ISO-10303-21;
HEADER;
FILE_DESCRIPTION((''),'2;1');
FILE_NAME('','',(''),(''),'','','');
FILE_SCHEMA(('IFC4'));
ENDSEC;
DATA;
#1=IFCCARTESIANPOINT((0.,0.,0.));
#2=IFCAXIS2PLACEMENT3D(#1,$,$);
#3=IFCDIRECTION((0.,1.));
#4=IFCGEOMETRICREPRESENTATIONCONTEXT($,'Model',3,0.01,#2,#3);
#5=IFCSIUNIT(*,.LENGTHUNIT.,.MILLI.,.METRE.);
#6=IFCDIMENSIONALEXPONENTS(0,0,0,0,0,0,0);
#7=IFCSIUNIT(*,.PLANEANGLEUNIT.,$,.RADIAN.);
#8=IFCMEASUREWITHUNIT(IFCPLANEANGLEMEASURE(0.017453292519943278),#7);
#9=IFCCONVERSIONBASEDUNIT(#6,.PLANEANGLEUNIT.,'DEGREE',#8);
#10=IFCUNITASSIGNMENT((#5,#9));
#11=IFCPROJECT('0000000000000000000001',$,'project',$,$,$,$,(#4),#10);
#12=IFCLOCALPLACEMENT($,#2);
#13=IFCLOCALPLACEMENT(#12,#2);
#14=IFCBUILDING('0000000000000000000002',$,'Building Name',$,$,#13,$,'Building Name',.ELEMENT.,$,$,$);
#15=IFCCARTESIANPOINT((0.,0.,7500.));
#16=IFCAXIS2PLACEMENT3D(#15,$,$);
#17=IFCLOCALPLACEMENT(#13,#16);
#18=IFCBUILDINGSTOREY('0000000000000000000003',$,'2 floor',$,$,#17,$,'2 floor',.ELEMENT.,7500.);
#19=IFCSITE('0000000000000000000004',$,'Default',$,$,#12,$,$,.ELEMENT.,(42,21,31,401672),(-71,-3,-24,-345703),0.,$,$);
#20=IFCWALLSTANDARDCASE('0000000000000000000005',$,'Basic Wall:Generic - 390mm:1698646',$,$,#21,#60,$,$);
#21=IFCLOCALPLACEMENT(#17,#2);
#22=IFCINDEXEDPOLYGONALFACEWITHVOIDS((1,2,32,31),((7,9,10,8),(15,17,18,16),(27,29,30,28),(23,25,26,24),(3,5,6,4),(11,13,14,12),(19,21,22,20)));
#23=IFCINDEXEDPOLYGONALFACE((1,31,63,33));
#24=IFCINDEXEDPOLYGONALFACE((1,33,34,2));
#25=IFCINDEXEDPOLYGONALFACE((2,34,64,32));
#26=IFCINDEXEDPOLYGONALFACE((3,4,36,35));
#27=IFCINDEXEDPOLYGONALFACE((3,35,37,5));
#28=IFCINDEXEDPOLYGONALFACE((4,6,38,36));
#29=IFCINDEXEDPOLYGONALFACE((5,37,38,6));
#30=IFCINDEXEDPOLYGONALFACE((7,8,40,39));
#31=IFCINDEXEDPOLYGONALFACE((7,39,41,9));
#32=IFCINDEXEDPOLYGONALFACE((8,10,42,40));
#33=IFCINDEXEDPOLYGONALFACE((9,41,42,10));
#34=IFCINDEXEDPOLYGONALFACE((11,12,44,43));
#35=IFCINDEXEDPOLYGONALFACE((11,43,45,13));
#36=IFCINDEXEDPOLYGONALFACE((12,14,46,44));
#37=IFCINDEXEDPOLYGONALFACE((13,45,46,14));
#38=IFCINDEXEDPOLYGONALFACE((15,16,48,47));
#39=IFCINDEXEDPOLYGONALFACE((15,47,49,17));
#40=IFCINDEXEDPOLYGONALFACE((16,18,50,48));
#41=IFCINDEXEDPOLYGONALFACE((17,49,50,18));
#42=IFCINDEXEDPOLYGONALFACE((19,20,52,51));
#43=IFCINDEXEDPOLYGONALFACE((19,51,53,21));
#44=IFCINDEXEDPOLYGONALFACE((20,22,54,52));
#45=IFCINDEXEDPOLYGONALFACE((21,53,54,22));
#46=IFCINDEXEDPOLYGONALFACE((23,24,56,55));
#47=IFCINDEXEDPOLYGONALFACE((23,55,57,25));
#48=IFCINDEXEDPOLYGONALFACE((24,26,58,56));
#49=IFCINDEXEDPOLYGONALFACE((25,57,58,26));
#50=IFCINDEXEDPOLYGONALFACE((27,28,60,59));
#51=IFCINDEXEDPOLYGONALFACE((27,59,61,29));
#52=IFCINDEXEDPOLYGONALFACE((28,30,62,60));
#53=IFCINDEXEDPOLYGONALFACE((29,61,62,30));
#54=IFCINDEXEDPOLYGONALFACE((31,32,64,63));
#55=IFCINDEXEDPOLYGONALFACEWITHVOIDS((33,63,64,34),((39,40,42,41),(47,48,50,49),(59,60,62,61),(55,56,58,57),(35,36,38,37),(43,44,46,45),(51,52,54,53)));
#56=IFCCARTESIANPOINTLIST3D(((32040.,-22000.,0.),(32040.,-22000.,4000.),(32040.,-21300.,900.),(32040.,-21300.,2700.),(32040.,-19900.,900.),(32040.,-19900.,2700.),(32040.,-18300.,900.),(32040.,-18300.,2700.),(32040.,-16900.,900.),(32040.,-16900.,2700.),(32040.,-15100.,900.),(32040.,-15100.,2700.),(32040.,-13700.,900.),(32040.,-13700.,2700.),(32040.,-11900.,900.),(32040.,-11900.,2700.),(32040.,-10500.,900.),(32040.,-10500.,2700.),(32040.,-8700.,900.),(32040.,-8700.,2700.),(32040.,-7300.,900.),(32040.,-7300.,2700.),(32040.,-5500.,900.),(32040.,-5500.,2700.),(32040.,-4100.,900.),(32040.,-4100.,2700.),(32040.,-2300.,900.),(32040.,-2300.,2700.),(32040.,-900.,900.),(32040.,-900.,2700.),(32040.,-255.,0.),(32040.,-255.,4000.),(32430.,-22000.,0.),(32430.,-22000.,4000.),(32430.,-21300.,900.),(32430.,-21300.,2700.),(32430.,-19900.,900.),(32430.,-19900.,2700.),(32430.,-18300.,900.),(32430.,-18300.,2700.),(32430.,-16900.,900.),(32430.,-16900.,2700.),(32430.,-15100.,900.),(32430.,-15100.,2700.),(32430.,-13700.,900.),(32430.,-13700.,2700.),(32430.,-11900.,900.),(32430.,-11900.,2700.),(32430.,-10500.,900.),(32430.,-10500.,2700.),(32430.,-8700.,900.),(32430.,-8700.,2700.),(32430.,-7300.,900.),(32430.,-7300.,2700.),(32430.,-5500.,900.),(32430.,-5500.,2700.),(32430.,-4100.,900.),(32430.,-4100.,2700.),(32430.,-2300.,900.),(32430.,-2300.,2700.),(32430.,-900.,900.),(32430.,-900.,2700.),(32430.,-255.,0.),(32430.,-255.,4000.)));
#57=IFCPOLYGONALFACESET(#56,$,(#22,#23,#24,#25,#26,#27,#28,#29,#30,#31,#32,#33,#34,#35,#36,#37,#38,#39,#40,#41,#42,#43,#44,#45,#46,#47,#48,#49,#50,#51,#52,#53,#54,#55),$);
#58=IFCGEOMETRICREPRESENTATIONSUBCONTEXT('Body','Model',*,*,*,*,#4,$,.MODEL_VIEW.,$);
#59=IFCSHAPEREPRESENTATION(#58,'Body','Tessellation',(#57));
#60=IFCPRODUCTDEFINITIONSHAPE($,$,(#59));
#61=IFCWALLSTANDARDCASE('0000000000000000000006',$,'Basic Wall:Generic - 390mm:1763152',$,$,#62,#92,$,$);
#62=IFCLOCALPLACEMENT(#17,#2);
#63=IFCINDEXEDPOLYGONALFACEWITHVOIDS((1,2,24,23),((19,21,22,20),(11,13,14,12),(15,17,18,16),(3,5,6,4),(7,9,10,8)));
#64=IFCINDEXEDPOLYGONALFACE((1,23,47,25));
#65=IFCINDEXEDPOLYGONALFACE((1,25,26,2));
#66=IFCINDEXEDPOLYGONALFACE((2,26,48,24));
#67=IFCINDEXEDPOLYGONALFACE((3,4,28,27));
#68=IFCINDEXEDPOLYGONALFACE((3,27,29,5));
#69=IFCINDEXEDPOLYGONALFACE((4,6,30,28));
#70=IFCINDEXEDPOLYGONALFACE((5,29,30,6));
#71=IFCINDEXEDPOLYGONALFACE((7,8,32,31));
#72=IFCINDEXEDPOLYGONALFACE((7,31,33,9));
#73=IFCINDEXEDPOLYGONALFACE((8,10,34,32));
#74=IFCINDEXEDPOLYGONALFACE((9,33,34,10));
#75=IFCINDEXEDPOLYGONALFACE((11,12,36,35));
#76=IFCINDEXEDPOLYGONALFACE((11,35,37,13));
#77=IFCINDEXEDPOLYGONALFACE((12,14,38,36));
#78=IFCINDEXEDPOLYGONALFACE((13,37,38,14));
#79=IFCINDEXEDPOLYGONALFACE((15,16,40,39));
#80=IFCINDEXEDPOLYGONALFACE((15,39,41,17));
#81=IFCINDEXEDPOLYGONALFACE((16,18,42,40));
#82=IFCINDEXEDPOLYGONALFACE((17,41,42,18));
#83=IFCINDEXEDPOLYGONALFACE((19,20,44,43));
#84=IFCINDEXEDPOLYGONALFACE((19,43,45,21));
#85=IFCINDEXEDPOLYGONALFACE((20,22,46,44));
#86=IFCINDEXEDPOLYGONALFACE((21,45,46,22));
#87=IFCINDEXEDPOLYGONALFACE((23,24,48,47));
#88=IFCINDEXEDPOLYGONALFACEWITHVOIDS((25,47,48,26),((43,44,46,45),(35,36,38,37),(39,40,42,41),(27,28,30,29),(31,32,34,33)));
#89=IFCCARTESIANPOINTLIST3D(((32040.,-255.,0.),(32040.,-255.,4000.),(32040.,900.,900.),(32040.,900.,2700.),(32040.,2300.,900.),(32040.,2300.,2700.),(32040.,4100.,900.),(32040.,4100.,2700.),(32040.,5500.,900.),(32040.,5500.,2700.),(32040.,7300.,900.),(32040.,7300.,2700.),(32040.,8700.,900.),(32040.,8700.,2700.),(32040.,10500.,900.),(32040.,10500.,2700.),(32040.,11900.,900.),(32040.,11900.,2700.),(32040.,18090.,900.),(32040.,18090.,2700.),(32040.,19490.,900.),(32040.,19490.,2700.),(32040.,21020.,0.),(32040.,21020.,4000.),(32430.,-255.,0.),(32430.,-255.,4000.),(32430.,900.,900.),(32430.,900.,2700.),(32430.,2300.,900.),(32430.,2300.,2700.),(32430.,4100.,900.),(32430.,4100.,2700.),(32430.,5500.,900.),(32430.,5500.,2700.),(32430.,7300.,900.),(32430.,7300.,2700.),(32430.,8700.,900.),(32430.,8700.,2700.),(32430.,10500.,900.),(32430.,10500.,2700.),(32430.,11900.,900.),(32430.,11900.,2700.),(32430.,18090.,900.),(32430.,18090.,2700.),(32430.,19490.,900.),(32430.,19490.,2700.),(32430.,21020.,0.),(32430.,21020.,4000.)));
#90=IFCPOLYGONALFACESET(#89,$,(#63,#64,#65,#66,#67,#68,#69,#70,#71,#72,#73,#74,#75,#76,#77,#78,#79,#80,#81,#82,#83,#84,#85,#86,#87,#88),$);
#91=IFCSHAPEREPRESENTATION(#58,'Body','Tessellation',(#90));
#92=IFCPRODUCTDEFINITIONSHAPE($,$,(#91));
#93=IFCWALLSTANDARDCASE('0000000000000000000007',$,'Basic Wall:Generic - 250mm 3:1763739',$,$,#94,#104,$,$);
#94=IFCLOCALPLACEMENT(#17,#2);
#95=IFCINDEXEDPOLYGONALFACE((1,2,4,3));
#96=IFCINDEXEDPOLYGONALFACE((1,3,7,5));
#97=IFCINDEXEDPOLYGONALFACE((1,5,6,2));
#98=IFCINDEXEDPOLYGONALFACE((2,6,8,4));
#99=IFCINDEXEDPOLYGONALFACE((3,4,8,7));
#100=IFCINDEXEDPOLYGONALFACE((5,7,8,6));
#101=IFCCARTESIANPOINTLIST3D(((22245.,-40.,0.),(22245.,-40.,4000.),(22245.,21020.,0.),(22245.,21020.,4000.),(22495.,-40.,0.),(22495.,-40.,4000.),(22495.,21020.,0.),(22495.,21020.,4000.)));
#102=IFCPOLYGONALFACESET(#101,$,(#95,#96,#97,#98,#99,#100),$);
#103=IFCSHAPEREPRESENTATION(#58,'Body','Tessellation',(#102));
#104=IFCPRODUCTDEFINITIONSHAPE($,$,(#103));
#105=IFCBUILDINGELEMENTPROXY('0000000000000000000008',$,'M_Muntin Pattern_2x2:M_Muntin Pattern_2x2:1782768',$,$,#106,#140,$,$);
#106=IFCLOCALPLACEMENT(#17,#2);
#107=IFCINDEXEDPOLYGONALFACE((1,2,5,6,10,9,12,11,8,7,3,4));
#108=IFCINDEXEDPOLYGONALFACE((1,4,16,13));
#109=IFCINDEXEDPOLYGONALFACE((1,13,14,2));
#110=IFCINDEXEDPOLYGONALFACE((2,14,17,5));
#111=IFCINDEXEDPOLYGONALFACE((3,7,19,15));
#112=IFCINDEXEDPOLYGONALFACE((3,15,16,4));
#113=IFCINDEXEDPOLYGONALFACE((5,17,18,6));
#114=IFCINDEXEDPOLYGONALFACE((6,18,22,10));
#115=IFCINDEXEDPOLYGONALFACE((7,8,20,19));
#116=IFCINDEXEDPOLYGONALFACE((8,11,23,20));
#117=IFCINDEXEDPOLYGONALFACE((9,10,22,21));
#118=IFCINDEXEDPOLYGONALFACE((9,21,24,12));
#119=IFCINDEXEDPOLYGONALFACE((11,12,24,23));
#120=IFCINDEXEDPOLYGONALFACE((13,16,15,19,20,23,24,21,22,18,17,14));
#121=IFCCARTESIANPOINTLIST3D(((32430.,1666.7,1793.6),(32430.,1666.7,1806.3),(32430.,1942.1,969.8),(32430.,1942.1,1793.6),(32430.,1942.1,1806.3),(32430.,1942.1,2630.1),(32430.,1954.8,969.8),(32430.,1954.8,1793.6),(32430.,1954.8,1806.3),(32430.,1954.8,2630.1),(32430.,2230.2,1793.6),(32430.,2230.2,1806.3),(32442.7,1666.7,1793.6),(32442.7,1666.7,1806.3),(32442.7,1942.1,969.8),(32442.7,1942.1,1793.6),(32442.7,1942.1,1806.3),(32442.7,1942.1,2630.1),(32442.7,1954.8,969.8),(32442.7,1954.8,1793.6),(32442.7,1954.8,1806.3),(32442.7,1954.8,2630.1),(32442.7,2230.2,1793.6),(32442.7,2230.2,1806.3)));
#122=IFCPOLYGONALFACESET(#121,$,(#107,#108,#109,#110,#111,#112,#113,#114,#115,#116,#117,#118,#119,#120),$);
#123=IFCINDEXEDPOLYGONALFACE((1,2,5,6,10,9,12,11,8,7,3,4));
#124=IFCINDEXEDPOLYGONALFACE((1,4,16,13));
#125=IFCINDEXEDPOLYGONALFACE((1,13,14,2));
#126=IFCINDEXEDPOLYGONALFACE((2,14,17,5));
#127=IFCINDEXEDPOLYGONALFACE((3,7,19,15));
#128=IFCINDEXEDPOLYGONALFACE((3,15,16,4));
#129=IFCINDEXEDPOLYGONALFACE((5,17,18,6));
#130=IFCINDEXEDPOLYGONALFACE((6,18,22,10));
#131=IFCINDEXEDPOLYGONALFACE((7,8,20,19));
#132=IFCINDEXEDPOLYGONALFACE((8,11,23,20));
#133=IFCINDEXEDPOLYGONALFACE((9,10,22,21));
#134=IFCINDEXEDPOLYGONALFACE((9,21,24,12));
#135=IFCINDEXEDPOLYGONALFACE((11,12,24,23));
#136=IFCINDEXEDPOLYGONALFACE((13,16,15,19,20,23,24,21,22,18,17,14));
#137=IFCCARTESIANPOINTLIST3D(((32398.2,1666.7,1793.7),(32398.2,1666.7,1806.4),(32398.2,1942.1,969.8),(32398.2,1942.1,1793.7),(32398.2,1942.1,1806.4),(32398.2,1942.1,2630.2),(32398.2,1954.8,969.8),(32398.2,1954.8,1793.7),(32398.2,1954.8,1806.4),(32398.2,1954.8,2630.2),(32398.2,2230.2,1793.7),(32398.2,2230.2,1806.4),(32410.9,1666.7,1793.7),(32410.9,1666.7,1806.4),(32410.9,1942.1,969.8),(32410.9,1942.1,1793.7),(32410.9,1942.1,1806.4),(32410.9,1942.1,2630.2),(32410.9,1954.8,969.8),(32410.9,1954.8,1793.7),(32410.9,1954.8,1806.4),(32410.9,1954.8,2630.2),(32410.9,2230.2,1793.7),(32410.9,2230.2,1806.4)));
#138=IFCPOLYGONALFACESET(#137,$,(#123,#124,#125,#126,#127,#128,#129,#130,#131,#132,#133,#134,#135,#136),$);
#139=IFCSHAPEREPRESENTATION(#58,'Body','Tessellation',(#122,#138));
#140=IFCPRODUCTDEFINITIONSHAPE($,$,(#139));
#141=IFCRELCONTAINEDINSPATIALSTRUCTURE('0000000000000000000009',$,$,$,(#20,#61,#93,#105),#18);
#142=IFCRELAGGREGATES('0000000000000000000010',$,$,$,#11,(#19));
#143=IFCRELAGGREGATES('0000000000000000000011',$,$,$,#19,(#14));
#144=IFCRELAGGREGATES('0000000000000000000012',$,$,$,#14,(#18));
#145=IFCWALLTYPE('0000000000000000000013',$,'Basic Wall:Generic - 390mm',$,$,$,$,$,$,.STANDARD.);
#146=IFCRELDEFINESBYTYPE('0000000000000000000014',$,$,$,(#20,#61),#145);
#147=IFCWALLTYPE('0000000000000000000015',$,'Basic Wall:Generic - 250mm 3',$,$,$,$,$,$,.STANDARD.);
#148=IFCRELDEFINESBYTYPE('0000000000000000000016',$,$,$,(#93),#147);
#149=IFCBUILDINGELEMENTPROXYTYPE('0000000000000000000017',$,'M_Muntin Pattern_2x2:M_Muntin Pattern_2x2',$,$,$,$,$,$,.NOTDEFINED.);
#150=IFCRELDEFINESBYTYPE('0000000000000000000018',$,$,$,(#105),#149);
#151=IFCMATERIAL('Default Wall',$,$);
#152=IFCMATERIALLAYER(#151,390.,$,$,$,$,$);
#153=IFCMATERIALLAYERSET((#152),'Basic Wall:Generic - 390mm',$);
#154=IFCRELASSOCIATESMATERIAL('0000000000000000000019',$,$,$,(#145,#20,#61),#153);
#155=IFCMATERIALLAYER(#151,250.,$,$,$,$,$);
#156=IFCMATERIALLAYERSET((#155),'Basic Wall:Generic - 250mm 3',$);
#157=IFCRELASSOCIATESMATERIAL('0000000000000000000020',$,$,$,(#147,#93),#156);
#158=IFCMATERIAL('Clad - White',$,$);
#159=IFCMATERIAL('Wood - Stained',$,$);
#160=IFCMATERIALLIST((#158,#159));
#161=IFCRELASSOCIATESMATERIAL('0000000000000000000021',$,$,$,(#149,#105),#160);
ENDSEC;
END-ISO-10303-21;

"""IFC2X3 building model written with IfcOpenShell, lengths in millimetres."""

from ifc_helpers import new_model, entity, si_unit, converted_unit, direction, frame, frame_2d, origin, place, context, subcontext, project, spatial, polyline, rectangle, outline, extrude, source, transform, mapped, material, material_list, layer, layer_set, layer_usage, type_object, type_shapes, element, save


model = new_model("IFC2X3")

# Units and contexts
model_context = context("Model", 3, precision=0.01, world=origin(), true_north=direction((0.0, 1.0)))
body_context = subcontext(model_context, "Body", "Model", "MODEL_VIEW")
ifc_project = project(units=[si_unit("LENGTHUNIT", "METRE", prefix="MILLI"), converted_unit("PLANEANGLEUNIT", "DEGREE", entity("IfcPlaneAngleMeasure", 0.017453292519943278), si_unit("PLANEANGLEUNIT", "RADIAN"), dimensions=[0, 0, 0, 0, 0, 0, 0])], contexts=[model_context])

# Site, building, storey
site_placement = place(None, origin())
site = spatial("IfcSite", under=ifc_project, at=site_placement, Name="Default", CompositionType="ELEMENT", RefLatitude=(42, 21, 31, 401672), RefLongitude=(-71, -3, -24, -345703), RefElevation=0.0)
building_placement = place(site_placement, origin())
building = spatial("IfcBuilding", under=site, at=building_placement, Name="Building Name", LongName="Building Name", CompositionType="ELEMENT")
storey_placement = place(building_placement, frame((0.0, 0.0, 7500.0)))
storey = spatial("IfcBuildingStorey", under=building, at=storey_placement, Name="2 floor", LongName="2 floor", CompositionType="ELEMENT", Elevation=7500.0)

# Walls, openings
ifc_material_1 = material(Name="Default Wall")
ifc_layer_1 = layer(ifc_material_1, 390.0)
ifc_layer_set_1 = layer_set([ifc_layer_1], Name="Basic Wall:Generic - 390mm")
ifc_layer_usage_1 = layer_usage(ifc_layer_set_1, "AXIS2", "NEGATIVE", 195.0)
wall_type_1 = type_object("IfcWallType", Name="Basic Wall:Generic - 390mm", PredefinedType="STANDARD", material=ifc_layer_set_1)
wall_1_placement = place(storey_placement, frame((32235.0, -255.0, 0.0), z_axis=(0.0, 0.0, 1.0), x_axis=(0.0, -1.0, 0.0)))
wall_1 = element("IfcWallStandardCase", 1, at=wall_1_placement, inside=storey, type_object=wall_type_1, material=ifc_layer_usage_1, Name="Basic Wall:Generic - 390mm:1698646", context=body_context, shape_type="SweptSolid", body=[
    extrude(rectangle(XDim=21745.0, YDim=390.0, at=frame_2d((10872.5, 0.0), x_axis=(-1.0, 0.0))), origin(), (0.0, 0.0, 1.0), 4000.0),
])
opening_1_placement = place(wall_1_placement, frame((645.0, -195.0, 900.0)))
element("IfcOpeningElement", 2, at=opening_1_placement, cuts=wall_1, ObjectType="Opening", context=body_context, shape_type="SweptSolid", body=[
    extrude(rectangle(XDim=1800.0, YDim=1400.0, at=frame_2d((900.0, 700.0), x_axis=(-1.0, 0.0))), frame((0.0, 0.0, 0.0), z_axis=(0.0, 1.0, 0.0), x_axis=(0.0, 0.0, 1.0)), (0.0, 0.0, 1.0), 390.0),
])
opening_2_placement = place(wall_1_placement, frame((3845.0, -195.0, 900.0)))
element("IfcOpeningElement", 3, at=opening_2_placement, cuts=wall_1, ObjectType="Opening", context=body_context, shape_type="SweptSolid", body=[
    extrude(rectangle(XDim=1800.0, YDim=1400.0, at=frame_2d((900.0, 700.0), x_axis=(-1.0, 0.0))), frame((0.0, 0.0, 0.0), z_axis=(0.0, 1.0, 0.0), x_axis=(0.0, 0.0, 1.0)), (0.0, 0.0, 1.0), 390.0),
])
opening_3_placement = place(wall_1_placement, frame((7045.0, -195.0, 900.0)))
element("IfcOpeningElement", 4, at=opening_3_placement, cuts=wall_1, ObjectType="Opening", context=body_context, shape_type="SweptSolid", body=[
    extrude(rectangle(XDim=1800.0, YDim=1400.0, at=frame_2d((900.0, 700.0), x_axis=(-1.0, 0.0))), frame((0.0, 0.0, 0.0), z_axis=(0.0, 1.0, 0.0), x_axis=(0.0, 0.0, 1.0)), (0.0, 0.0, 1.0), 390.0),
])
opening_4_placement = place(wall_1_placement, frame((10245.0, -195.0, 900.0)))
element("IfcOpeningElement", 5, at=opening_4_placement, cuts=wall_1, ObjectType="Opening", context=body_context, shape_type="SweptSolid", body=[
    extrude(rectangle(XDim=1800.0, YDim=1400.0, at=frame_2d((900.0, 700.0), x_axis=(-1.0, 0.0))), frame((0.0, 0.0, 0.0), z_axis=(0.0, 1.0, 0.0), x_axis=(0.0, 0.0, 1.0)), (0.0, 0.0, 1.0), 390.0),
])
opening_5_placement = place(wall_1_placement, frame((13445.0, -195.0, 900.0)))
element("IfcOpeningElement", 6, at=opening_5_placement, cuts=wall_1, ObjectType="Opening", context=body_context, shape_type="SweptSolid", body=[
    extrude(rectangle(XDim=1800.0, YDim=1400.0, at=frame_2d((900.0, 700.0), x_axis=(-1.0, 0.0))), frame((0.0, 0.0, 0.0), z_axis=(0.0, 1.0, 0.0), x_axis=(0.0, 0.0, 1.0)), (0.0, 0.0, 1.0), 390.0),
])
opening_6_placement = place(wall_1_placement, frame((16645.0, -195.0, 900.0)))
element("IfcOpeningElement", 7, at=opening_6_placement, cuts=wall_1, ObjectType="Opening", context=body_context, shape_type="SweptSolid", body=[
    extrude(rectangle(XDim=1800.0, YDim=1400.0, at=frame_2d((900.0, 700.0), x_axis=(-1.0, 0.0))), frame((0.0, 0.0, 0.0), z_axis=(0.0, 1.0, 0.0), x_axis=(0.0, 0.0, 1.0)), (0.0, 0.0, 1.0), 390.0),
])
opening_7_placement = place(wall_1_placement, frame((19645.0, -195.0, 900.0)))
element("IfcOpeningElement", 8, at=opening_7_placement, cuts=wall_1, ObjectType="Opening", context=body_context, shape_type="SweptSolid", body=[
    extrude(rectangle(XDim=1800.0, YDim=1400.0, at=frame_2d((900.0, 700.0), x_axis=(-1.0, 0.0))), frame((0.0, 0.0, 0.0), z_axis=(0.0, 1.0, 0.0), x_axis=(0.0, 0.0, 1.0)), (0.0, 0.0, 1.0), 390.0),
])
ifc_layer_usage_2 = layer_usage(ifc_layer_set_1, "AXIS2", "NEGATIVE", 195.0)
wall_2_placement = place(storey_placement, frame((32235.0, -255.0, 0.0), z_axis=(0.0, 0.0, 1.0), x_axis=(0.0, 1.0, 0.0)))
wall_2 = element("IfcWallStandardCase", 9, at=wall_2_placement, inside=storey, type_object=wall_type_1, material=ifc_layer_usage_2, Name="Basic Wall:Generic - 390mm:1763152", context=body_context, shape_type="SweptSolid", body=[
    extrude(rectangle(XDim=21275.0, YDim=390.0, at=frame_2d((10637.5, 0.0), x_axis=(-1.0, 0.0))), origin(), (0.0, 0.0, 1.0), 4000.0),
])
opening_8_placement = place(wall_2_placement, frame((19745.0, 195.0, 900.0)))
element("IfcOpeningElement", 10, at=opening_8_placement, cuts=wall_2, ObjectType="Opening", context=body_context, shape_type="SweptSolid", body=[
    extrude(rectangle(XDim=1800.0, YDim=1400.0, at=frame_2d((900.0, 700.0), x_axis=(-1.0, 0.0))), frame((0.0, 0.0, 0.0), z_axis=(0.0, -1.0, 0.0), x_axis=(0.0, 0.0, 1.0)), (0.0, 0.0, 1.0), 390.0),
])
opening_9_placement = place(wall_2_placement, frame((12155.0, 195.0, 900.0)))
element("IfcOpeningElement", 11, at=opening_9_placement, cuts=wall_2, ObjectType="Opening", context=body_context, shape_type="SweptSolid", body=[
    extrude(rectangle(XDim=1800.0, YDim=1400.0, at=frame_2d((900.0, 700.0), x_axis=(-1.0, 0.0))), frame((0.0, 0.0, 0.0), z_axis=(0.0, -1.0, 0.0), x_axis=(0.0, 0.0, 1.0)), (0.0, 0.0, 1.0), 390.0),
])
opening_10_placement = place(wall_2_placement, frame((8955.0, 195.0, 900.0)))
element("IfcOpeningElement", 12, at=opening_10_placement, cuts=wall_2, ObjectType="Opening", context=body_context, shape_type="SweptSolid", body=[
    extrude(rectangle(XDim=1800.0, YDim=1400.0, at=frame_2d((900.0, 700.0), x_axis=(-1.0, 0.0))), frame((0.0, 0.0, 0.0), z_axis=(0.0, -1.0, 0.0), x_axis=(0.0, 0.0, 1.0)), (0.0, 0.0, 1.0), 390.0),
])
opening_11_placement = place(wall_2_placement, frame((5755.0, 195.0, 900.0)))
element("IfcOpeningElement", 13, at=opening_11_placement, cuts=wall_2, ObjectType="Opening", context=body_context, shape_type="SweptSolid", body=[
    extrude(rectangle(XDim=1800.0, YDim=1400.0, at=frame_2d((900.0, 700.0), x_axis=(-1.0, 0.0))), frame((0.0, 0.0, 0.0), z_axis=(0.0, -1.0, 0.0), x_axis=(0.0, 0.0, 1.0)), (0.0, 0.0, 1.0), 390.0),
])
opening_12_placement = place(wall_2_placement, frame((2555.0, 195.0, 900.0)))
element("IfcOpeningElement", 14, at=opening_12_placement, cuts=wall_2, ObjectType="Opening", context=body_context, shape_type="SweptSolid", body=[
    extrude(rectangle(XDim=1800.0, YDim=1400.0, at=frame_2d((900.0, 700.0), x_axis=(-1.0, 0.0))), frame((0.0, 0.0, 0.0), z_axis=(0.0, -1.0, 0.0), x_axis=(0.0, 0.0, 1.0)), (0.0, 0.0, 1.0), 390.0),
])

# Wall
ifc_layer_2 = layer(ifc_material_1, 250.0)
ifc_layer_set_2 = layer_set([ifc_layer_2], Name="Basic Wall:Generic - 250mm 3")
ifc_layer_usage_3 = layer_usage(ifc_layer_set_2, "AXIS2", "NEGATIVE", 125.0)
wall_type_2 = type_object("IfcWallType", Name="Basic Wall:Generic - 250mm 3", PredefinedType="STANDARD", material=ifc_layer_set_2)
wall_3_placement = place(storey_placement, frame((22370.0, -40.0, 0.0), z_axis=(0.0, 0.0, 1.0), x_axis=(0.0, 1.0, 0.0)))
element("IfcWallStandardCase", 15, at=wall_3_placement, inside=storey, type_object=wall_type_2, material=ifc_layer_usage_3, Name="Basic Wall:Generic - 250mm 3:1763739", context=body_context, shape_type="SweptSolid", body=[
    extrude(rectangle(XDim=21060.0, YDim=250.0, at=frame_2d((10530.0, 0.0), x_axis=(-1.0, 0.0))), origin(), (0.0, 0.0, 1.0), 4000.0),
])

# Building element proxy
ifc_material_2 = material(Name="Clad - White")
ifc_material_3 = material(Name="Wood - Stained")
ifc_material_list = material_list([ifc_material_2, ifc_material_3])
building_element_proxy_type_1 = type_object("IfcBuildingElementProxyType", Name="M_Muntin Pattern_2x2:M_Muntin Pattern_2x2", PredefinedType="NOTDEFINED", material=ifc_material_list)
shared_shape_1 = source(origin(), body_context, "Body", "SweptSolid", [
    extrude(outline(polyline([(6.4, -6.4), (830.1, -6.4), (830.1, 6.3), (6.4, 6.3), (6.4, 281.7), (-6.3, 281.7), (-6.3, 6.3), (-830.2, 6.3), (-830.2, -6.4), (-6.3, -6.4), (-6.3, -281.7), (6.4, -281.7), (6.4, -6.4)])), frame((0.0, 9.5, 830.1), z_axis=(0.0, 1.0, 0.0), x_axis=(0.0, 0.0, 1.0)), (0.0, 0.0, 1.0), 12.7),
    extrude(outline(polyline([(6.4, -6.4), (830.2, -6.4), (830.2, 6.3), (6.4, 6.3), (6.4, 281.7), (-6.3, 281.7), (-6.3, 6.3), (-830.2, 6.3), (-830.2, -6.4), (-6.3, -6.4), (-6.3, -281.7), (6.4, -281.7), (6.4, -6.4)])), frame((0.0, -22.2, 830.2), z_axis=(0.0, 1.0, 0.0), x_axis=(0.0, 0.0, 1.0)), (0.0, 0.0, 1.0), 12.7),
])
type_shapes(building_element_proxy_type_1, [shared_shape_1])
for number, where, z_axis, x_axis, name in (
    (16, (32420.5, 1948.4, 969.8), (0.0, 0.0, 1.0), (0.0, -1.0, 0.0), "M_Muntin Pattern_2x2:M_Muntin Pattern_2x2:1782768"),
):
    element("IfcBuildingElementProxy", number, at=place(storey_placement, frame(where, z_axis=z_axis, x_axis=x_axis)), inside=storey, type_object=building_element_proxy_type_1, material=ifc_material_list, Name=name, context=body_context, shape_type="MappedRepresentation", body=[
        mapped(shared_shape_1, transform((0.0, 0.0, 0.0), scale=1.0)),
    ])

save(model, "model.ifc")
